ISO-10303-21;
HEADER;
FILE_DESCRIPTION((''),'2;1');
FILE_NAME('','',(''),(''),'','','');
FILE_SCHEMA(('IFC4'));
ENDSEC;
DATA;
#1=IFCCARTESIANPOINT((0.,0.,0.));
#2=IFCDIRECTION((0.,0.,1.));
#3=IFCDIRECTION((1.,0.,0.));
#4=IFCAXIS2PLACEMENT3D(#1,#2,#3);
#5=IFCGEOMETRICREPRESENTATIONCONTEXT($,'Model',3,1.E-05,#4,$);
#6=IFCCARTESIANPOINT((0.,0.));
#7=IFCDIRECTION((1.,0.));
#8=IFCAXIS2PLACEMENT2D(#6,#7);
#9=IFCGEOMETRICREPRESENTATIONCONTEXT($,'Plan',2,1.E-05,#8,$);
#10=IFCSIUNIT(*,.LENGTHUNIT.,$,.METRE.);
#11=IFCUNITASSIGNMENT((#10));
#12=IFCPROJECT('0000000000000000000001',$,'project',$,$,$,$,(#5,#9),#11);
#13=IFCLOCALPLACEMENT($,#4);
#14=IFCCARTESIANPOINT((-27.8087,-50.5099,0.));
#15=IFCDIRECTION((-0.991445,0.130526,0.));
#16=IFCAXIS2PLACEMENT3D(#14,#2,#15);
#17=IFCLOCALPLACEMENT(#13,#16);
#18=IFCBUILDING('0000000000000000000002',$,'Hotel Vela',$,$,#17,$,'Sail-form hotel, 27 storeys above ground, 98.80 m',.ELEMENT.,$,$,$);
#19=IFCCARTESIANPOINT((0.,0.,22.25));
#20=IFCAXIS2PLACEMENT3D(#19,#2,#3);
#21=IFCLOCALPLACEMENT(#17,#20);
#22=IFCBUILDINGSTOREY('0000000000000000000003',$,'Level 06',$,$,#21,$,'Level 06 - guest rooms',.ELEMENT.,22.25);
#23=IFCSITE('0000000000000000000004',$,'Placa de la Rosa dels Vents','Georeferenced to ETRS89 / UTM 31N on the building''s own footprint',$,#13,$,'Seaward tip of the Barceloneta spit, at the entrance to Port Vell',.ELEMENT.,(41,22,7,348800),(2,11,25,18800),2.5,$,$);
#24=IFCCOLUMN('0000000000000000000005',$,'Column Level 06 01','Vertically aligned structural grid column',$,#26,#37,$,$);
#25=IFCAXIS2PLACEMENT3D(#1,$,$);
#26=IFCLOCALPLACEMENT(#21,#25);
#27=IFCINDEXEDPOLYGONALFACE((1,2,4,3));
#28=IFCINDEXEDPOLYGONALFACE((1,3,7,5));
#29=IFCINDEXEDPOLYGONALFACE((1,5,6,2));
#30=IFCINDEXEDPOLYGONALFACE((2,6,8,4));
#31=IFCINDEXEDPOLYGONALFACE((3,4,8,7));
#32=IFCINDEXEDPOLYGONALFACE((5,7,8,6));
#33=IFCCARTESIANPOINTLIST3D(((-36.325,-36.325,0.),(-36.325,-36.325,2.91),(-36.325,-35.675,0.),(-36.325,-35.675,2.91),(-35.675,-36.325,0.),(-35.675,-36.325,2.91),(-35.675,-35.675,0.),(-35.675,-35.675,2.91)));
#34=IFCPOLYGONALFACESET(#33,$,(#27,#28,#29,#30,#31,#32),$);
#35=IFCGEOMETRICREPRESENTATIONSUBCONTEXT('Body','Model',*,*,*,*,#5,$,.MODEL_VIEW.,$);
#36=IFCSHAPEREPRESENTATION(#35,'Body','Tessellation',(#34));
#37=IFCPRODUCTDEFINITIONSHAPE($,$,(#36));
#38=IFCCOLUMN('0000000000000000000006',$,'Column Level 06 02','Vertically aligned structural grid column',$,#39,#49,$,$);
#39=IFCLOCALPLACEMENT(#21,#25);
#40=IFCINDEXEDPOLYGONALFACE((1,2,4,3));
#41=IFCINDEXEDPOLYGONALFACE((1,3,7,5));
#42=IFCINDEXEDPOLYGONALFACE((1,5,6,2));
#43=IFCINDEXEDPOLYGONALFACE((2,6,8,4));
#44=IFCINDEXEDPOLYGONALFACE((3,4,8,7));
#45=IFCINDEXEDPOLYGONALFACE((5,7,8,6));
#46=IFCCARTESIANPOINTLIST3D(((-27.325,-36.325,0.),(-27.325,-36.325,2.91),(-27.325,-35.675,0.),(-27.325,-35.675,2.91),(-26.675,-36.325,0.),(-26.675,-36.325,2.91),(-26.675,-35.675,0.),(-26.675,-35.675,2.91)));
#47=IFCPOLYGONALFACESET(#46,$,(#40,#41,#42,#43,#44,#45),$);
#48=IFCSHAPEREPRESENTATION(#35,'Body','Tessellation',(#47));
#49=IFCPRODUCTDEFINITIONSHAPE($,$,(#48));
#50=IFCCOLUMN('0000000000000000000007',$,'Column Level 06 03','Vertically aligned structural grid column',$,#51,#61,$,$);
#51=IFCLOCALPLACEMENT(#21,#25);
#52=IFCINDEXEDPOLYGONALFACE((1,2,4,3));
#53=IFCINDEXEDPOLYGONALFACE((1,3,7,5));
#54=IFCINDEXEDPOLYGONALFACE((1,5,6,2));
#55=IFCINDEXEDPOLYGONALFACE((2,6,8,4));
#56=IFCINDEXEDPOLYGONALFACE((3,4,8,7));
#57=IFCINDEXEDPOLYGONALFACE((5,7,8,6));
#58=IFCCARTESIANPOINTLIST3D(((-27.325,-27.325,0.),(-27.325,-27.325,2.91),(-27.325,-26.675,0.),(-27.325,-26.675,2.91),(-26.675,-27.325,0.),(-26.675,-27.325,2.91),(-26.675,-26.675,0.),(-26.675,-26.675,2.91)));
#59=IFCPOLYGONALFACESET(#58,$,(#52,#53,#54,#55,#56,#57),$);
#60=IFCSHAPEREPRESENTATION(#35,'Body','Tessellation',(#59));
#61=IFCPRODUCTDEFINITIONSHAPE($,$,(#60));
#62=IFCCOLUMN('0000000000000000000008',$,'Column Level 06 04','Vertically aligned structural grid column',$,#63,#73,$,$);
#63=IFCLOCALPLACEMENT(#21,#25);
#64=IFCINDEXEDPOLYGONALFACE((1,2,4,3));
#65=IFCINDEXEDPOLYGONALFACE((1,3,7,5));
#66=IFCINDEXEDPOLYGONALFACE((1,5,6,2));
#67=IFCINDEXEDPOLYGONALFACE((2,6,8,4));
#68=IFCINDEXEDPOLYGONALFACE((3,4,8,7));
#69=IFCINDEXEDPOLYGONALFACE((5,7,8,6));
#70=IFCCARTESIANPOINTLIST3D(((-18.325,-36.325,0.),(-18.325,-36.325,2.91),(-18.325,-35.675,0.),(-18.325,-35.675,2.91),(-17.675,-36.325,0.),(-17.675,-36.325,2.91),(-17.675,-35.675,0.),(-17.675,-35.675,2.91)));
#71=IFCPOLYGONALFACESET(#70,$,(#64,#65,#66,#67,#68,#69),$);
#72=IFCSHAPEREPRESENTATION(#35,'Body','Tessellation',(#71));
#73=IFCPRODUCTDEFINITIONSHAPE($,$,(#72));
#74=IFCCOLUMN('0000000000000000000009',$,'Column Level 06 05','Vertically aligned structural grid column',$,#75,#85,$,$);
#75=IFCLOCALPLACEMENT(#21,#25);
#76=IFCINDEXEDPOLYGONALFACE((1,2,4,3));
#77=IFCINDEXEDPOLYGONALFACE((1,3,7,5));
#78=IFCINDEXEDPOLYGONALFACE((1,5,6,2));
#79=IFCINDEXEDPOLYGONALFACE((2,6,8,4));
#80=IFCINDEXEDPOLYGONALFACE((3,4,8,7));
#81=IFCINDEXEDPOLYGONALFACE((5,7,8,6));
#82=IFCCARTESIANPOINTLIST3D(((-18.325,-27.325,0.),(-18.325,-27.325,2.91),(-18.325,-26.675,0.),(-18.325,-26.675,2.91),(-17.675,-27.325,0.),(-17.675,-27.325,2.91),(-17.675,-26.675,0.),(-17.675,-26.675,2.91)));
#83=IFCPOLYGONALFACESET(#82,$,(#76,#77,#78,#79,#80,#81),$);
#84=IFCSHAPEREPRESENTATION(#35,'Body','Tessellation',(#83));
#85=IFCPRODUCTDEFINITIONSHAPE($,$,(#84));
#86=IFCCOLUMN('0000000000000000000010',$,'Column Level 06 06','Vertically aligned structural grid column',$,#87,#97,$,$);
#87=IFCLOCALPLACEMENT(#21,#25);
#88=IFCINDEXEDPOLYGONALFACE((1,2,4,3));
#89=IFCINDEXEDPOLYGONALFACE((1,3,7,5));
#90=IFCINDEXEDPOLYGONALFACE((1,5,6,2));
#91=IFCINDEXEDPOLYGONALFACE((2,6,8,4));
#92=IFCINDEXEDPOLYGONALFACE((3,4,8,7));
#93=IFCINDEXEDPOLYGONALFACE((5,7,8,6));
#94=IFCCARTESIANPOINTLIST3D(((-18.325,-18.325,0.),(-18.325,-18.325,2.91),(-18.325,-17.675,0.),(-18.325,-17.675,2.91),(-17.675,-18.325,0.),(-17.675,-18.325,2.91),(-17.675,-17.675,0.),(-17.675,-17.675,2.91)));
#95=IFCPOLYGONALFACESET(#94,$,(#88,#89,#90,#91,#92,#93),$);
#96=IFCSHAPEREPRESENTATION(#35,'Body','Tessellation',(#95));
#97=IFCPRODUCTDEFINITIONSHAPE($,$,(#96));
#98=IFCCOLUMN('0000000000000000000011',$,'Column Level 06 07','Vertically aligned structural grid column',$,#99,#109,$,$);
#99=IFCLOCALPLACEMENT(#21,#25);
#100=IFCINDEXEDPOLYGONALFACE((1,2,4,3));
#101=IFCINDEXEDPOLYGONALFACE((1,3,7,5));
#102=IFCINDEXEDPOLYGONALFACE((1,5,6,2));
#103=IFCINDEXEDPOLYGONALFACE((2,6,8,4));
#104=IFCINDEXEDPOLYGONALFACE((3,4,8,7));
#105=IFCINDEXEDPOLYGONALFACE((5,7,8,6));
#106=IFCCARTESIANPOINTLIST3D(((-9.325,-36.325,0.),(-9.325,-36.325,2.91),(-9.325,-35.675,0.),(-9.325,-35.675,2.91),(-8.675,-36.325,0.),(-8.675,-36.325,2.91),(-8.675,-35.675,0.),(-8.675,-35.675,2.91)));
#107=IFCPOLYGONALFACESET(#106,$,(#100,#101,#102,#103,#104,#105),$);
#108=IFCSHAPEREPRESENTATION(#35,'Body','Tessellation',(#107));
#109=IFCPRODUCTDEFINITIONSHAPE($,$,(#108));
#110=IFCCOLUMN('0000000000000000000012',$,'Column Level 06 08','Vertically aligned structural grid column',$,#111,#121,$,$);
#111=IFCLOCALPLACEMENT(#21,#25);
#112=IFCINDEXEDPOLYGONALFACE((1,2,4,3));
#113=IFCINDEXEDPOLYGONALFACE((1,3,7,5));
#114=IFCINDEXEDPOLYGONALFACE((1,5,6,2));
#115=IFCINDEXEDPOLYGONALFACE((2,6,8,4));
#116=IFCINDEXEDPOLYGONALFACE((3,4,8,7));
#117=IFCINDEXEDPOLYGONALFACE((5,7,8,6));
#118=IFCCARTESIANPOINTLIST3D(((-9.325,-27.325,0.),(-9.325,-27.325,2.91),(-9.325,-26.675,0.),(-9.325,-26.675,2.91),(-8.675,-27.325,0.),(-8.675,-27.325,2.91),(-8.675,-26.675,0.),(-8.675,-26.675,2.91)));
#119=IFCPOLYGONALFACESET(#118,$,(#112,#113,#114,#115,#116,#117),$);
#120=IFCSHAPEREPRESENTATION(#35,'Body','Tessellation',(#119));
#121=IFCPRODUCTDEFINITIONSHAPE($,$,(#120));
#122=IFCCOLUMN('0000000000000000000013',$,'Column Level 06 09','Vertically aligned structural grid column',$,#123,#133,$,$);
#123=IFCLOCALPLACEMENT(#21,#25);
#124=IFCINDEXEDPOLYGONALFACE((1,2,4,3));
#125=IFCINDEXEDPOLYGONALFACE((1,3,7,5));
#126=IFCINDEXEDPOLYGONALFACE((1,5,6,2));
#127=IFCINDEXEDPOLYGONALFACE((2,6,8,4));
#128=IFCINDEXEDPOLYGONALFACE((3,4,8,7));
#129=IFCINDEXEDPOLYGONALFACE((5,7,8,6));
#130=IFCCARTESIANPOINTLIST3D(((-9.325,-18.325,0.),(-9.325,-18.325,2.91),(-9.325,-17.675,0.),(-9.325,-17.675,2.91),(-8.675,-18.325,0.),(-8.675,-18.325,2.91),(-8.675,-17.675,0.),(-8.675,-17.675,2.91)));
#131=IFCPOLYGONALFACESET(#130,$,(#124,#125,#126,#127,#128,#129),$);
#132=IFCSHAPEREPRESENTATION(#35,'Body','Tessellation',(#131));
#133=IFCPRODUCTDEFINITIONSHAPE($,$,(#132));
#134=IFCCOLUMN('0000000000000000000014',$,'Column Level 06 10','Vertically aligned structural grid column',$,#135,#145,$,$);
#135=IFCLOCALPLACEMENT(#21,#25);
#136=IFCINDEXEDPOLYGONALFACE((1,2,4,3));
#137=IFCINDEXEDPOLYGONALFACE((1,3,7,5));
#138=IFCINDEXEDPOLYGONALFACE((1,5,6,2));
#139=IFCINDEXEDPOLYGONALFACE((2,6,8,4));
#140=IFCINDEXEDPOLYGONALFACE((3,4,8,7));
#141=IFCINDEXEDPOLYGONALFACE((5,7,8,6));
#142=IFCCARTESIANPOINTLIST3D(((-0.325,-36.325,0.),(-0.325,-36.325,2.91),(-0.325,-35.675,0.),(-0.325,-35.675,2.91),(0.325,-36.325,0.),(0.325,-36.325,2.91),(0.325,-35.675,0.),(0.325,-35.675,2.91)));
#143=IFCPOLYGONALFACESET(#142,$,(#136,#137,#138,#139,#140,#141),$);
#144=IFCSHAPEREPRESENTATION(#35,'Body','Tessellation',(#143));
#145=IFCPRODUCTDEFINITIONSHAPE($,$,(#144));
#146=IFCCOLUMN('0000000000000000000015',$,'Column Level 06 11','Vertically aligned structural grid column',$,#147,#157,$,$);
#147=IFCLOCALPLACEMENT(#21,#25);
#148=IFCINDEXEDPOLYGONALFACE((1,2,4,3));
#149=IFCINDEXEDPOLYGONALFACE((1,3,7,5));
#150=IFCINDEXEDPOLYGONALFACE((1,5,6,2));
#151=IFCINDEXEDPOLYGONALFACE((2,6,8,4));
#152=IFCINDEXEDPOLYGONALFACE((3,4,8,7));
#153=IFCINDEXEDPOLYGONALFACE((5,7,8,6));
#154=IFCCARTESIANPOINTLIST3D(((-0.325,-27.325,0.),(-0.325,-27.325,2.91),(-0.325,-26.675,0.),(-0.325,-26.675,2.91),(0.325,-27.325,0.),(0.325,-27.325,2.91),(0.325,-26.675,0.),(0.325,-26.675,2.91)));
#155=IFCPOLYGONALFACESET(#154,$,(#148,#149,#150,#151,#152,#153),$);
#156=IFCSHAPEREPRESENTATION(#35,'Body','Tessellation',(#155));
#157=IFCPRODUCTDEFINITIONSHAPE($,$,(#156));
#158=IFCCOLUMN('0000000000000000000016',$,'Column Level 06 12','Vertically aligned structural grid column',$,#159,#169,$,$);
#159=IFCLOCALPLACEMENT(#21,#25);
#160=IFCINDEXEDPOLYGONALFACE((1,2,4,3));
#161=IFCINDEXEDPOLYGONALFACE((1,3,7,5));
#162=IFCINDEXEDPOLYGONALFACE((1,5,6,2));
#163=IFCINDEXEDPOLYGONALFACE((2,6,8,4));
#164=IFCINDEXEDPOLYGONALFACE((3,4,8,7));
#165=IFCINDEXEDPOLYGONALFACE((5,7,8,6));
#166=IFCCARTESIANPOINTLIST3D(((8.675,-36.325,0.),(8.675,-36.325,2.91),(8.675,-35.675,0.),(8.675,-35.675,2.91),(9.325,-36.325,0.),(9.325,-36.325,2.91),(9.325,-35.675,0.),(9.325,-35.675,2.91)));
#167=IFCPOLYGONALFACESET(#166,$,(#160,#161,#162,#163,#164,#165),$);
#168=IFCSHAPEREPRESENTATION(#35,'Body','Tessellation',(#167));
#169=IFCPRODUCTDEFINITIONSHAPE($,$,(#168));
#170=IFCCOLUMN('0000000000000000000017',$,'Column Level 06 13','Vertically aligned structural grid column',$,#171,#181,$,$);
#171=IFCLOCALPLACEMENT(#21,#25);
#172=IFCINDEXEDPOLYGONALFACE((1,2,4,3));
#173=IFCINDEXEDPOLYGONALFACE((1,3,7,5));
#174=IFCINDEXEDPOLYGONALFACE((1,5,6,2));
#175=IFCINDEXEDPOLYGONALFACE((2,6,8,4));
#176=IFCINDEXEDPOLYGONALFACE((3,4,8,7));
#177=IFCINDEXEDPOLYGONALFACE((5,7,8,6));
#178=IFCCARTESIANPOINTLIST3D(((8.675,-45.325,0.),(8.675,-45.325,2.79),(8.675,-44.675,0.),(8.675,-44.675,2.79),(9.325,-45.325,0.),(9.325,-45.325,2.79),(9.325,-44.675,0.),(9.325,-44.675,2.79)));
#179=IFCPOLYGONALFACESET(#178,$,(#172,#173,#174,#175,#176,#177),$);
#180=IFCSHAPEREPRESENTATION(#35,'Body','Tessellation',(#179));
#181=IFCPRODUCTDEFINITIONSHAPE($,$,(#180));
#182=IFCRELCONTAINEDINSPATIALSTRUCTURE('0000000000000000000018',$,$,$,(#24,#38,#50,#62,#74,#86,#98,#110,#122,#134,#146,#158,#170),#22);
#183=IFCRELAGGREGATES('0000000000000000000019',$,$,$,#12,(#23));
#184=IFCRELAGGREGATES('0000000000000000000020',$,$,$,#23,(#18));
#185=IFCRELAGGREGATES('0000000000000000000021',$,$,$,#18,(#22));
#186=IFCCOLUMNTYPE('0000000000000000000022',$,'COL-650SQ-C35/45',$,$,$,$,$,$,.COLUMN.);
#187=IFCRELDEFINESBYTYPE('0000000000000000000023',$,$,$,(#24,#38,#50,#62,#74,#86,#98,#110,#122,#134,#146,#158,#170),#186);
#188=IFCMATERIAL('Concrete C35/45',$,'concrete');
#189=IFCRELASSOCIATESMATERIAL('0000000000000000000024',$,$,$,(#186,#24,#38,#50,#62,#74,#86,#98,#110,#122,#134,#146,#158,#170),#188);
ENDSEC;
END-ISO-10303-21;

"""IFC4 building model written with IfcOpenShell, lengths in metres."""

from ifc_helpers import new_model, si_unit, frame, origin_with_axes, origin_2d_with_axis, place, context, subcontext, project, spatial, line, indexed_curve, rectangle, outline, extrude, material, material_profile, profile_set, profile_usage, type_object, element, save


model = new_model("IFC4")

# Units and contexts
model_context = context("Model", 3, precision=1e-05, world=origin_with_axes())
plan_context = context("Plan", 2, precision=1e-05, world=origin_2d_with_axis())
body_context = subcontext(model_context, "Body", "Model", "MODEL_VIEW")
ifc_project = project(units=[si_unit("LENGTHUNIT", "METRE")], contexts=[model_context, plan_context])

# Site, building, storey
site_placement = place(None, origin_with_axes())
site = spatial("IfcSite", under=ifc_project, at=site_placement, Name="Placa de la Rosa dels Vents", Description="Georeferenced to ETRS89 / UTM 31N on the building's own footprint", LongName="Seaward tip of the Barceloneta spit, at the entrance to Port Vell", CompositionType="ELEMENT", RefLatitude=(41, 22, 7, 348800), RefLongitude=(2, 11, 25, 18800), RefElevation=2.5)
building_placement = place(site_placement, frame((-27.8087, -50.5099, 0.0), z_axis=(0.0, 0.0, 1.0), x_axis=(-0.991445, 0.130526, 0.0)))
building = spatial("IfcBuilding", under=site, at=building_placement, Name="Hotel Vela", LongName="Sail-form hotel, 27 storeys above ground, 98.80 m", CompositionType="ELEMENT")
storey_placement = place(building_placement, frame((0.0, 0.0, 22.25), z_axis=(0.0, 0.0, 1.0), x_axis=(1.0, 0.0, 0.0)))
storey = spatial("IfcBuildingStorey", under=building, at=storey_placement, Name="Level 06", LongName="Level 06 - guest rooms", CompositionType="ELEMENT", Elevation=22.25)

# Columns
ifc_material = material(Name="Concrete C35/45", Category="concrete")
ifc_material_profile = material_profile(ifc_material, rectangle(XDim=0.65, YDim=0.65))
ifc_profile_set = profile_set([ifc_material_profile], Name="COL-650SQ-C35/45")
ifc_profile_usage_1 = profile_usage(ifc_profile_set)
column_type = type_object("IfcColumnType", Name="COL-650SQ-C35/45", PredefinedType="COLUMN", material=ifc_profile_set)
column_1_placement = place(storey_placement, frame((-36.325, -36.325, 0.0), z_axis=(0.0, 0.0, 1.0), x_axis=(1.0, 0.0, 0.0)))
element("IfcColumn", 1, at=column_1_placement, inside=storey, type_object=column_type, material=ifc_profile_usage_1, Name="Column Level 06 01", Description="Vertically aligned structural grid column", context=body_context, shape_type="SweptSolid", body=[
    extrude(outline(indexed_curve([(0.0, 0.0), (0.65, 0.0), (0.65, 0.65), (0.0, 0.65)], segments=[line(1, 2, 3, 4, 1)])), origin_with_axes(), (0.0, 0.0, 1.0), 2.91),
])
ifc_profile_usage_2 = profile_usage(ifc_profile_set)
column_2_placement = place(storey_placement, frame((-27.325, -36.325, 0.0), z_axis=(0.0, 0.0, 1.0), x_axis=(1.0, 0.0, 0.0)))
element("IfcColumn", 2, at=column_2_placement, inside=storey, type_object=column_type, material=ifc_profile_usage_2, Name="Column Level 06 02", Description="Vertically aligned structural grid column", context=body_context, shape_type="SweptSolid", body=[
    extrude(outline(indexed_curve([(0.0, 0.0), (0.65, 0.0), (0.65, 0.65), (0.0, 0.65)], segments=[line(1, 2, 3, 4, 1)])), origin_with_axes(), (0.0, 0.0, 1.0), 2.91),
])
ifc_profile_usage_3 = profile_usage(ifc_profile_set)
column_3_placement = place(storey_placement, frame((-27.325, -27.325, 0.0), z_axis=(0.0, 0.0, 1.0), x_axis=(1.0, 0.0, 0.0)))
element("IfcColumn", 3, at=column_3_placement, inside=storey, type_object=column_type, material=ifc_profile_usage_3, Name="Column Level 06 03", Description="Vertically aligned structural grid column", context=body_context, shape_type="SweptSolid", body=[
    extrude(outline(indexed_curve([(0.0, 0.0), (0.65, 0.0), (0.65, 0.65), (0.0, 0.65)], segments=[line(1, 2, 3, 4, 1)])), origin_with_axes(), (0.0, 0.0, 1.0), 2.91),
])
ifc_profile_usage_4 = profile_usage(ifc_profile_set)
column_4_placement = place(storey_placement, frame((-18.325, -36.325, 0.0), z_axis=(0.0, 0.0, 1.0), x_axis=(1.0, 0.0, 0.0)))
element("IfcColumn", 4, at=column_4_placement, inside=storey, type_object=column_type, material=ifc_profile_usage_4, Name="Column Level 06 04", Description="Vertically aligned structural grid column", context=body_context, shape_type="SweptSolid", body=[
    extrude(outline(indexed_curve([(0.0, 0.0), (0.65, 0.0), (0.65, 0.65), (0.0, 0.65)], segments=[line(1, 2, 3, 4, 1)])), origin_with_axes(), (0.0, 0.0, 1.0), 2.91),
])
ifc_profile_usage_5 = profile_usage(ifc_profile_set)
column_5_placement = place(storey_placement, frame((-18.325, -27.325, 0.0), z_axis=(0.0, 0.0, 1.0), x_axis=(1.0, 0.0, 0.0)))
element("IfcColumn", 5, at=column_5_placement, inside=storey, type_object=column_type, material=ifc_profile_usage_5, Name="Column Level 06 05", Description="Vertically aligned structural grid column", context=body_context, shape_type="SweptSolid", body=[
    extrude(outline(indexed_curve([(0.0, 0.0), (0.65, 0.0), (0.65, 0.65), (0.0, 0.65)], segments=[line(1, 2, 3, 4, 1)])), origin_with_axes(), (0.0, 0.0, 1.0), 2.91),
])
ifc_profile_usage_6 = profile_usage(ifc_profile_set)
column_6_placement = place(storey_placement, frame((-18.325, -18.325, 0.0), z_axis=(0.0, 0.0, 1.0), x_axis=(1.0, 0.0, 0.0)))
element("IfcColumn", 6, at=column_6_placement, inside=storey, type_object=column_type, material=ifc_profile_usage_6, Name="Column Level 06 06", Description="Vertically aligned structural grid column", context=body_context, shape_type="SweptSolid", body=[
    extrude(outline(indexed_curve([(0.0, 0.0), (0.65, 0.0), (0.65, 0.65), (0.0, 0.65)], segments=[line(1, 2, 3, 4, 1)])), origin_with_axes(), (0.0, 0.0, 1.0), 2.91),
])
ifc_profile_usage_7 = profile_usage(ifc_profile_set)
column_7_placement = place(storey_placement, frame((-9.325, -36.325, 0.0), z_axis=(0.0, 0.0, 1.0), x_axis=(1.0, 0.0, 0.0)))
element("IfcColumn", 7, at=column_7_placement, inside=storey, type_object=column_type, material=ifc_profile_usage_7, Name="Column Level 06 07", Description="Vertically aligned structural grid column", context=body_context, shape_type="SweptSolid", body=[
    extrude(outline(indexed_curve([(0.0, 0.0), (0.65, 0.0), (0.65, 0.65), (0.0, 0.65)], segments=[line(1, 2, 3, 4, 1)])), origin_with_axes(), (0.0, 0.0, 1.0), 2.91),
])
ifc_profile_usage_8 = profile_usage(ifc_profile_set)
column_8_placement = place(storey_placement, frame((-9.325, -27.325, 0.0), z_axis=(0.0, 0.0, 1.0), x_axis=(1.0, 0.0, 0.0)))
element("IfcColumn", 8, at=column_8_placement, inside=storey, type_object=column_type, material=ifc_profile_usage_8, Name="Column Level 06 08", Description="Vertically aligned structural grid column", context=body_context, shape_type="SweptSolid", body=[
    extrude(outline(indexed_curve([(0.0, 0.0), (0.65, 0.0), (0.65, 0.65), (0.0, 0.65)], segments=[line(1, 2, 3, 4, 1)])), origin_with_axes(), (0.0, 0.0, 1.0), 2.91),
])
ifc_profile_usage_9 = profile_usage(ifc_profile_set)
column_9_placement = place(storey_placement, frame((-9.325, -18.325, 0.0), z_axis=(0.0, 0.0, 1.0), x_axis=(1.0, 0.0, 0.0)))
element("IfcColumn", 9, at=column_9_placement, inside=storey, type_object=column_type, material=ifc_profile_usage_9, Name="Column Level 06 09", Description="Vertically aligned structural grid column", context=body_context, shape_type="SweptSolid", body=[
    extrude(outline(indexed_curve([(0.0, 0.0), (0.65, 0.0), (0.65, 0.65), (0.0, 0.65)], segments=[line(1, 2, 3, 4, 1)])), origin_with_axes(), (0.0, 0.0, 1.0), 2.91),
])
ifc_profile_usage_10 = profile_usage(ifc_profile_set)
column_10_placement = place(storey_placement, frame((-0.325, -36.325, 0.0), z_axis=(0.0, 0.0, 1.0), x_axis=(1.0, 0.0, 0.0)))
element("IfcColumn", 10, at=column_10_placement, inside=storey, type_object=column_type, material=ifc_profile_usage_10, Name="Column Level 06 10", Description="Vertically aligned structural grid column", context=body_context, shape_type="SweptSolid", body=[
    extrude(outline(indexed_curve([(0.0, 0.0), (0.65, 0.0), (0.65, 0.65), (0.0, 0.65)], segments=[line(1, 2, 3, 4, 1)])), origin_with_axes(), (0.0, 0.0, 1.0), 2.91),
])
ifc_profile_usage_11 = profile_usage(ifc_profile_set)
column_11_placement = place(storey_placement, frame((-0.325, -27.325, 0.0), z_axis=(0.0, 0.0, 1.0), x_axis=(1.0, 0.0, 0.0)))
element("IfcColumn", 11, at=column_11_placement, inside=storey, type_object=column_type, material=ifc_profile_usage_11, Name="Column Level 06 11", Description="Vertically aligned structural grid column", context=body_context, shape_type="SweptSolid", body=[
    extrude(outline(indexed_curve([(0.0, 0.0), (0.65, 0.0), (0.65, 0.65), (0.0, 0.65)], segments=[line(1, 2, 3, 4, 1)])), origin_with_axes(), (0.0, 0.0, 1.0), 2.91),
])
ifc_profile_usage_12 = profile_usage(ifc_profile_set)
column_12_placement = place(storey_placement, frame((8.675, -36.325, 0.0), z_axis=(0.0, 0.0, 1.0), x_axis=(1.0, 0.0, 0.0)))
element("IfcColumn", 12, at=column_12_placement, inside=storey, type_object=column_type, material=ifc_profile_usage_12, Name="Column Level 06 12", Description="Vertically aligned structural grid column", context=body_context, shape_type="SweptSolid", body=[
    extrude(outline(indexed_curve([(0.0, 0.0), (0.65, 0.0), (0.65, 0.65), (0.0, 0.65)], segments=[line(1, 2, 3, 4, 1)])), origin_with_axes(), (0.0, 0.0, 1.0), 2.91),
])
ifc_profile_usage_13 = profile_usage(ifc_profile_set)
column_13_placement = place(storey_placement, frame((8.675, -45.325, 0.0), z_axis=(0.0, 0.0, 1.0), x_axis=(1.0, 0.0, 0.0)))
element("IfcColumn", 13, at=column_13_placement, inside=storey, type_object=column_type, material=ifc_profile_usage_13, Name="Column Level 06 13", Description="Vertically aligned structural grid column", context=body_context, shape_type="SweptSolid", body=[
    extrude(outline(indexed_curve([(0.0, 0.0), (0.65, 0.0), (0.65, 0.65), (0.0, 0.65)], segments=[line(1, 2, 3, 4, 1)])), origin_with_axes(), (0.0, 0.0, 1.0), 2.79),
])

save(model, "model.ifc")
